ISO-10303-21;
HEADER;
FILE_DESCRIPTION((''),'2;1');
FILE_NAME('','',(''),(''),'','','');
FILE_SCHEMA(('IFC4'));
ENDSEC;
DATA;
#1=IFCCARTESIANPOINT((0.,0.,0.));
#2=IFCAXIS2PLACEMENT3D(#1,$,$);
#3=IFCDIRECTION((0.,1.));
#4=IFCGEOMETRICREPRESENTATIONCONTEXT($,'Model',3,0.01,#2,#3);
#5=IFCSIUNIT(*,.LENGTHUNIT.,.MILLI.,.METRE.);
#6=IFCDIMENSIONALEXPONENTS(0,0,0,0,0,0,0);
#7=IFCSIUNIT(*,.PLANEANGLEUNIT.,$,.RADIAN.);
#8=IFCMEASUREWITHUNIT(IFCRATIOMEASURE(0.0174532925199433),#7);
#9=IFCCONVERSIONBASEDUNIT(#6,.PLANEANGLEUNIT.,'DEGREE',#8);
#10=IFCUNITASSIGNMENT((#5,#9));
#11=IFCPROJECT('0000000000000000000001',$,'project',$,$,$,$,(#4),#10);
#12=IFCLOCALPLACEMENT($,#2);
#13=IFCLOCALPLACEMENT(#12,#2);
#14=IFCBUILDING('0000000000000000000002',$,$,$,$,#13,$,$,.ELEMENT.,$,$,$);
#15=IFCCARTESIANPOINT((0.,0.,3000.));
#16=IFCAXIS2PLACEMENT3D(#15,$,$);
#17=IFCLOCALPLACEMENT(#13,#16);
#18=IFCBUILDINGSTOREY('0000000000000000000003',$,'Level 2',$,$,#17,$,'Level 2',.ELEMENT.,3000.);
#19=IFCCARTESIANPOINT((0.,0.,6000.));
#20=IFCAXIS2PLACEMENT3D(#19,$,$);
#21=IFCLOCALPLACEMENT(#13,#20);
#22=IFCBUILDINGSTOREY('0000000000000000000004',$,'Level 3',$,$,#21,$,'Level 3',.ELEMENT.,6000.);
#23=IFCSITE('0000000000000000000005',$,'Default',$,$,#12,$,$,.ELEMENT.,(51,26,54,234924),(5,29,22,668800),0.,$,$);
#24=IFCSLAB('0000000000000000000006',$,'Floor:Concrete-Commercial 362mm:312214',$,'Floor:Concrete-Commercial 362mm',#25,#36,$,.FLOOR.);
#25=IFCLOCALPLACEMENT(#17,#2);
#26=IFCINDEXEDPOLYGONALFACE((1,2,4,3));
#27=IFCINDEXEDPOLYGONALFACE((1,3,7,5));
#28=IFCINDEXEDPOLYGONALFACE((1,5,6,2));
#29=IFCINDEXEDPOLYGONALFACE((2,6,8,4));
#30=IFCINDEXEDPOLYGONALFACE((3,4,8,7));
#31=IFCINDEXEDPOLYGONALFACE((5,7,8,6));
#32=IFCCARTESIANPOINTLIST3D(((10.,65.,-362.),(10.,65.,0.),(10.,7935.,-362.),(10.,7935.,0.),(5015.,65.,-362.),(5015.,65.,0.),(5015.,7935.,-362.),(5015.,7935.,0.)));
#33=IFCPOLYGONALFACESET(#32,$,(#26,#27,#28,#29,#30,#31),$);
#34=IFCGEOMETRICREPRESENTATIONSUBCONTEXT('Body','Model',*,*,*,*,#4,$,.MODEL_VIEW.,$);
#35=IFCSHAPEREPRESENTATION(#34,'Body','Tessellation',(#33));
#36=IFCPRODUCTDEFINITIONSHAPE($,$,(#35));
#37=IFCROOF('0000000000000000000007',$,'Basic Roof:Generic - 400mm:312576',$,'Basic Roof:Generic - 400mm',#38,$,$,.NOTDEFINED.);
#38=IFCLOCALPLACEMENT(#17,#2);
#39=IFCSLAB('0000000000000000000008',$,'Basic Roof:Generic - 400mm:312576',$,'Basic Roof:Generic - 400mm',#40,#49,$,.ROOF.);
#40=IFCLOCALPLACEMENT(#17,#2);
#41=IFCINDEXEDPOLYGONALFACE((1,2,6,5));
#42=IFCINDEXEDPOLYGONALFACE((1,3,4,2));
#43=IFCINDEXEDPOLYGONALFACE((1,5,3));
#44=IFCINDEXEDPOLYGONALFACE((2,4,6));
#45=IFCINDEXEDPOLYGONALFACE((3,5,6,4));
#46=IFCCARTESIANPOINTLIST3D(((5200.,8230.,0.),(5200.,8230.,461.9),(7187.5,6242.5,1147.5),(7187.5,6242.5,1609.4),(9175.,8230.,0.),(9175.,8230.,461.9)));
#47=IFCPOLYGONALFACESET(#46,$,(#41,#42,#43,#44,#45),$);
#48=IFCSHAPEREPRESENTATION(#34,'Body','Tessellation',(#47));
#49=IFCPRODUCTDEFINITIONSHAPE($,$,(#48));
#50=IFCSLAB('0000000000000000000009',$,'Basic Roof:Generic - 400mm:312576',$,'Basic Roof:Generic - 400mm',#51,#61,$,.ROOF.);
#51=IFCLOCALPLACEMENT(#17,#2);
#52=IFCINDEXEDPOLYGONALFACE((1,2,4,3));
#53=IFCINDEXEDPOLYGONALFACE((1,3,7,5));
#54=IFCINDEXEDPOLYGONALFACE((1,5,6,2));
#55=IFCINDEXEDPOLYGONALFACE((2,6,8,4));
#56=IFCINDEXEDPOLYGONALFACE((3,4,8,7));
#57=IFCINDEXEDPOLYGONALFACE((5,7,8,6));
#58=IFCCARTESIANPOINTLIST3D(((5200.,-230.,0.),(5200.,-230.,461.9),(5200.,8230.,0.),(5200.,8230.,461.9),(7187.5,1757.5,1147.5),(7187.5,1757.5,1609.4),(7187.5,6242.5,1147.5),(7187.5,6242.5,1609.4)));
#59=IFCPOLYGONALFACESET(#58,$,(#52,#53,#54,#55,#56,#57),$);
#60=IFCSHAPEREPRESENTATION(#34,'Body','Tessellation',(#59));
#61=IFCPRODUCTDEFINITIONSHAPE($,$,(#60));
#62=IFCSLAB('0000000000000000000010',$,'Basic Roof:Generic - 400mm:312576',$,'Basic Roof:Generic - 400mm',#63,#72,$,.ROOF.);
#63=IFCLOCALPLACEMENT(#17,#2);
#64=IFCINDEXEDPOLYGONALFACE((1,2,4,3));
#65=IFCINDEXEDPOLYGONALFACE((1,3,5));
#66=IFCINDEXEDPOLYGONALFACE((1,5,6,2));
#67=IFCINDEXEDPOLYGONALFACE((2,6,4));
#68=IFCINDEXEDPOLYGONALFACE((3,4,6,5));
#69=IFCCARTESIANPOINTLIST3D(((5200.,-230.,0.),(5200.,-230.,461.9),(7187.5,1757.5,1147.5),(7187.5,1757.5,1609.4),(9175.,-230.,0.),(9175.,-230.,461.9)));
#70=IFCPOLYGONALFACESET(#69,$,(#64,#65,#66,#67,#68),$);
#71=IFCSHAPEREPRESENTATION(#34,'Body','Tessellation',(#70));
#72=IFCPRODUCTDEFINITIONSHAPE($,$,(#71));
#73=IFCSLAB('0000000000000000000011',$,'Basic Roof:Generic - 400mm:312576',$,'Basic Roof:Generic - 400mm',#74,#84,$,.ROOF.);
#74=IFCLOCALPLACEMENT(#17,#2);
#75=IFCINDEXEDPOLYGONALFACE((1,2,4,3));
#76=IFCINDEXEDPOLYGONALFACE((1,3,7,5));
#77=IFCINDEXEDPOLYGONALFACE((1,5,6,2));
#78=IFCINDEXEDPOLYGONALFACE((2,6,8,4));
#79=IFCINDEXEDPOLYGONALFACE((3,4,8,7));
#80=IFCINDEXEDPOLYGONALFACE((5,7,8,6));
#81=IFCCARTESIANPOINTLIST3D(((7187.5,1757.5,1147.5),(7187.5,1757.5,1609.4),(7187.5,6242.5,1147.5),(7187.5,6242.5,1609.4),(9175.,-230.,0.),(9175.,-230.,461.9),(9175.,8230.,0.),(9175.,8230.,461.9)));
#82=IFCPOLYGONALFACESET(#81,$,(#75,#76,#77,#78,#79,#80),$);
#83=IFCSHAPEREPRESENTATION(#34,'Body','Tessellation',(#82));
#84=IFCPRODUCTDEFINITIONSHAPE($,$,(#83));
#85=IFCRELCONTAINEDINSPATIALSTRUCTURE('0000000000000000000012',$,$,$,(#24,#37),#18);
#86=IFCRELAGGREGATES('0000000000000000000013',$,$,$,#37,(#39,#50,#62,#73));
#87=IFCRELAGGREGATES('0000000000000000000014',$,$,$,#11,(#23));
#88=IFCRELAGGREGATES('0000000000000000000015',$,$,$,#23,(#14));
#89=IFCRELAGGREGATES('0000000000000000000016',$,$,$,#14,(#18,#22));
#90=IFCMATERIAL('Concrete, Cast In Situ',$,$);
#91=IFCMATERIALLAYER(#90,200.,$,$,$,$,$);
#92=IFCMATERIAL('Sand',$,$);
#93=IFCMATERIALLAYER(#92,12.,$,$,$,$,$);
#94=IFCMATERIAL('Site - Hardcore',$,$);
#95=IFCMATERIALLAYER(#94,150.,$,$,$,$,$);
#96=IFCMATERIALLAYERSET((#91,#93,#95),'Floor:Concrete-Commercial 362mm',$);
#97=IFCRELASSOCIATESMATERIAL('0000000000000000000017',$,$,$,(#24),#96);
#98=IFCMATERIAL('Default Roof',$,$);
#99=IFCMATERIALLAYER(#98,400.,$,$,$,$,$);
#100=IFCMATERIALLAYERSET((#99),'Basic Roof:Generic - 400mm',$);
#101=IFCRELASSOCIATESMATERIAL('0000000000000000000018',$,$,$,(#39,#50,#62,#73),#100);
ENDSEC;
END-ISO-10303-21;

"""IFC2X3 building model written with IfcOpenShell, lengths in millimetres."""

from ifc_helpers import new_model, entity, si_unit, converted_unit, direction, frame, origin, origin_2d_with_axis, place, context, subcontext, project, spatial, polyline, rectangle, outline, extrude, material, layer, layer_set, layer_usage, element, aggregate, save


model = new_model("IFC2X3")

# Units and contexts
model_context = context("Model", 3, precision=0.01, world=origin(), true_north=direction((0.0, 1.0)))
body_context = subcontext(model_context, "Body", "Model", "MODEL_VIEW")
ifc_project = project(units=[si_unit("LENGTHUNIT", "METRE", prefix="MILLI"), converted_unit("PLANEANGLEUNIT", "DEGREE", entity("IfcRatioMeasure", 0.0174532925199433), si_unit("PLANEANGLEUNIT", "RADIAN"), dimensions=[0, 0, 0, 0, 0, 0, 0])], contexts=[model_context])

# Site, building, storey
site_placement = place(None, origin())
site = spatial("IfcSite", under=ifc_project, at=site_placement, Name="Default", CompositionType="ELEMENT", RefLatitude=(51, 26, 54, 234924), RefLongitude=(5, 29, 22, 668800), RefElevation=0.0)
building_placement = place(site_placement, origin())
building = spatial("IfcBuilding", under=site, at=building_placement, CompositionType="ELEMENT")
storey_1_placement = place(building_placement, frame((0.0, 0.0, 3000.0)))
storey_1 = spatial("IfcBuildingStorey", under=building, at=storey_1_placement, Name="Level 2", LongName="Level 2", CompositionType="ELEMENT", Elevation=3000.0)

# Slab
ifc_material_1 = material(Name="Concrete, Cast In Situ")
ifc_layer_1 = layer(ifc_material_1, 200.0)
ifc_material_2 = material(Name="Sand")
ifc_layer_2 = layer(ifc_material_2, 12.0)
ifc_material_3 = material(Name="Site - Hardcore")
ifc_layer_3 = layer(ifc_material_3, 150.0)
ifc_layer_set_1 = layer_set([ifc_layer_1, ifc_layer_2, ifc_layer_3], Name="Floor:Concrete-Commercial 362mm")
ifc_layer_usage_1 = layer_usage(ifc_layer_set_1, "AXIS3", "POSITIVE", 0.0)
slab_1_placement = place(storey_1_placement, origin())
element("IfcSlab", 1, at=slab_1_placement, inside=storey_1, material=ifc_layer_usage_1, Name="Floor:Concrete-Commercial 362mm:312214", ObjectType="Floor:Concrete-Commercial 362mm", PredefinedType="FLOOR", context=body_context, shape_type="SweptSolid", body=[
    extrude(rectangle(XDim=7870.0, YDim=5005.0, at=origin_2d_with_axis()), frame((2512.5, 4000.0, 0.0), z_axis=(0.0, 0.0, -1.0), x_axis=(0.0, 1.0, 0.0)), (0.0, 0.0, 1.0), 362.0),
])

# Roof, slabs
roof_placement = place(storey_1_placement, frame((5200.0, -230.0, 0.0)))
roof = element("IfcRoof", 2, at=roof_placement, inside=storey_1, Name="Basic Roof:Generic - 400mm:312576", ObjectType="Basic Roof:Generic - 400mm", ShapeType="NOTDEFINED")
ifc_material_4 = material(Name="Default Roof")
ifc_layer_4 = layer(ifc_material_4, 400.0)
ifc_layer_set_2 = layer_set([ifc_layer_4], Name="Basic Roof:Generic - 400mm")
slab_2_placement = place(roof_placement, origin())
slab_2 = element("IfcSlab", 3, at=slab_2_placement, material=ifc_layer_set_2, Name="Basic Roof:Generic - 400mm:312576", ObjectType="Basic Roof:Generic - 400mm", PredefinedType="ROOF", context=body_context, shape_type="SweptSolid", body=[
    extrude(outline(polyline([(1987.5, 1147.5), (-1987.5, 1147.5), (0.0, -1147.5), (1987.5, 1147.5)])), frame((1987.5, 7466.3, 573.7), z_axis=(0.0, 0.5, 0.866025), x_axis=(1.0, 0.0, 0.0)), (0.0, -0.5, 0.866025), 461.9),
])
slab_3_placement = place(roof_placement, origin())
slab_3 = element("IfcSlab", 4, at=slab_3_placement, material=ifc_layer_set_2, Name="Basic Roof:Generic - 400mm:312576", ObjectType="Basic Roof:Generic - 400mm", PredefinedType="ROOF", context=body_context, shape_type="SweptSolid", body=[
    extrude(outline(polyline([(-1147.5, 4230.0), (-1147.5, -4230.0), (1147.5, -2242.5), (1147.5, 2242.5), (-1147.5, 4230.0)])), frame((993.7, 4230.0, 573.7), z_axis=(-0.5, 0.0, 0.866025), x_axis=(0.866025, 0.0, 0.5)), (0.5, 0.0, 0.866025), 461.9),
])
slab_4_placement = place(roof_placement, origin())
slab_4 = element("IfcSlab", 5, at=slab_4_placement, material=ifc_layer_set_2, Name="Basic Roof:Generic - 400mm:312576", ObjectType="Basic Roof:Generic - 400mm", PredefinedType="ROOF", context=body_context, shape_type="SweptSolid", body=[
    extrude(outline(polyline([(-1987.5, -1147.5), (1987.5, -1147.5), (0.0, 1147.5), (-1987.5, -1147.5)])), frame((1987.5, 993.7, 573.7), z_axis=(0.0, -0.5, 0.866025), x_axis=(1.0, 0.0, 0.0)), (0.0, 0.5, 0.866025), 461.9),
])
slab_5_placement = place(roof_placement, origin())
slab_5 = element("IfcSlab", 6, at=slab_5_placement, material=ifc_layer_set_2, Name="Basic Roof:Generic - 400mm:312576", ObjectType="Basic Roof:Generic - 400mm", PredefinedType="ROOF", context=body_context, shape_type="SweptSolid", body=[
    extrude(outline(polyline([(-1147.5, 2242.5), (-1147.5, -2242.5), (1147.5, -4230.0), (1147.5, 4230.0), (-1147.5, 2242.5)])), frame((2981.2, 4230.0, 573.7), z_axis=(0.5, 0.0, 0.866025), x_axis=(0.866025, 0.0, -0.5)), (-0.5, 0.0, 0.866025), 461.9),
])
aggregate(roof, [slab_2, slab_3, slab_4, slab_5])

# Shared definitions
storey_2_placement = place(building_placement, frame((0.0, 0.0, 6000.0)))
storey_2 = spatial("IfcBuildingStorey", under=building, at=storey_2_placement, Name="Level 3", LongName="Level 3", CompositionType="ELEMENT", Elevation=6000.0)

save(model, "model.ifc")
